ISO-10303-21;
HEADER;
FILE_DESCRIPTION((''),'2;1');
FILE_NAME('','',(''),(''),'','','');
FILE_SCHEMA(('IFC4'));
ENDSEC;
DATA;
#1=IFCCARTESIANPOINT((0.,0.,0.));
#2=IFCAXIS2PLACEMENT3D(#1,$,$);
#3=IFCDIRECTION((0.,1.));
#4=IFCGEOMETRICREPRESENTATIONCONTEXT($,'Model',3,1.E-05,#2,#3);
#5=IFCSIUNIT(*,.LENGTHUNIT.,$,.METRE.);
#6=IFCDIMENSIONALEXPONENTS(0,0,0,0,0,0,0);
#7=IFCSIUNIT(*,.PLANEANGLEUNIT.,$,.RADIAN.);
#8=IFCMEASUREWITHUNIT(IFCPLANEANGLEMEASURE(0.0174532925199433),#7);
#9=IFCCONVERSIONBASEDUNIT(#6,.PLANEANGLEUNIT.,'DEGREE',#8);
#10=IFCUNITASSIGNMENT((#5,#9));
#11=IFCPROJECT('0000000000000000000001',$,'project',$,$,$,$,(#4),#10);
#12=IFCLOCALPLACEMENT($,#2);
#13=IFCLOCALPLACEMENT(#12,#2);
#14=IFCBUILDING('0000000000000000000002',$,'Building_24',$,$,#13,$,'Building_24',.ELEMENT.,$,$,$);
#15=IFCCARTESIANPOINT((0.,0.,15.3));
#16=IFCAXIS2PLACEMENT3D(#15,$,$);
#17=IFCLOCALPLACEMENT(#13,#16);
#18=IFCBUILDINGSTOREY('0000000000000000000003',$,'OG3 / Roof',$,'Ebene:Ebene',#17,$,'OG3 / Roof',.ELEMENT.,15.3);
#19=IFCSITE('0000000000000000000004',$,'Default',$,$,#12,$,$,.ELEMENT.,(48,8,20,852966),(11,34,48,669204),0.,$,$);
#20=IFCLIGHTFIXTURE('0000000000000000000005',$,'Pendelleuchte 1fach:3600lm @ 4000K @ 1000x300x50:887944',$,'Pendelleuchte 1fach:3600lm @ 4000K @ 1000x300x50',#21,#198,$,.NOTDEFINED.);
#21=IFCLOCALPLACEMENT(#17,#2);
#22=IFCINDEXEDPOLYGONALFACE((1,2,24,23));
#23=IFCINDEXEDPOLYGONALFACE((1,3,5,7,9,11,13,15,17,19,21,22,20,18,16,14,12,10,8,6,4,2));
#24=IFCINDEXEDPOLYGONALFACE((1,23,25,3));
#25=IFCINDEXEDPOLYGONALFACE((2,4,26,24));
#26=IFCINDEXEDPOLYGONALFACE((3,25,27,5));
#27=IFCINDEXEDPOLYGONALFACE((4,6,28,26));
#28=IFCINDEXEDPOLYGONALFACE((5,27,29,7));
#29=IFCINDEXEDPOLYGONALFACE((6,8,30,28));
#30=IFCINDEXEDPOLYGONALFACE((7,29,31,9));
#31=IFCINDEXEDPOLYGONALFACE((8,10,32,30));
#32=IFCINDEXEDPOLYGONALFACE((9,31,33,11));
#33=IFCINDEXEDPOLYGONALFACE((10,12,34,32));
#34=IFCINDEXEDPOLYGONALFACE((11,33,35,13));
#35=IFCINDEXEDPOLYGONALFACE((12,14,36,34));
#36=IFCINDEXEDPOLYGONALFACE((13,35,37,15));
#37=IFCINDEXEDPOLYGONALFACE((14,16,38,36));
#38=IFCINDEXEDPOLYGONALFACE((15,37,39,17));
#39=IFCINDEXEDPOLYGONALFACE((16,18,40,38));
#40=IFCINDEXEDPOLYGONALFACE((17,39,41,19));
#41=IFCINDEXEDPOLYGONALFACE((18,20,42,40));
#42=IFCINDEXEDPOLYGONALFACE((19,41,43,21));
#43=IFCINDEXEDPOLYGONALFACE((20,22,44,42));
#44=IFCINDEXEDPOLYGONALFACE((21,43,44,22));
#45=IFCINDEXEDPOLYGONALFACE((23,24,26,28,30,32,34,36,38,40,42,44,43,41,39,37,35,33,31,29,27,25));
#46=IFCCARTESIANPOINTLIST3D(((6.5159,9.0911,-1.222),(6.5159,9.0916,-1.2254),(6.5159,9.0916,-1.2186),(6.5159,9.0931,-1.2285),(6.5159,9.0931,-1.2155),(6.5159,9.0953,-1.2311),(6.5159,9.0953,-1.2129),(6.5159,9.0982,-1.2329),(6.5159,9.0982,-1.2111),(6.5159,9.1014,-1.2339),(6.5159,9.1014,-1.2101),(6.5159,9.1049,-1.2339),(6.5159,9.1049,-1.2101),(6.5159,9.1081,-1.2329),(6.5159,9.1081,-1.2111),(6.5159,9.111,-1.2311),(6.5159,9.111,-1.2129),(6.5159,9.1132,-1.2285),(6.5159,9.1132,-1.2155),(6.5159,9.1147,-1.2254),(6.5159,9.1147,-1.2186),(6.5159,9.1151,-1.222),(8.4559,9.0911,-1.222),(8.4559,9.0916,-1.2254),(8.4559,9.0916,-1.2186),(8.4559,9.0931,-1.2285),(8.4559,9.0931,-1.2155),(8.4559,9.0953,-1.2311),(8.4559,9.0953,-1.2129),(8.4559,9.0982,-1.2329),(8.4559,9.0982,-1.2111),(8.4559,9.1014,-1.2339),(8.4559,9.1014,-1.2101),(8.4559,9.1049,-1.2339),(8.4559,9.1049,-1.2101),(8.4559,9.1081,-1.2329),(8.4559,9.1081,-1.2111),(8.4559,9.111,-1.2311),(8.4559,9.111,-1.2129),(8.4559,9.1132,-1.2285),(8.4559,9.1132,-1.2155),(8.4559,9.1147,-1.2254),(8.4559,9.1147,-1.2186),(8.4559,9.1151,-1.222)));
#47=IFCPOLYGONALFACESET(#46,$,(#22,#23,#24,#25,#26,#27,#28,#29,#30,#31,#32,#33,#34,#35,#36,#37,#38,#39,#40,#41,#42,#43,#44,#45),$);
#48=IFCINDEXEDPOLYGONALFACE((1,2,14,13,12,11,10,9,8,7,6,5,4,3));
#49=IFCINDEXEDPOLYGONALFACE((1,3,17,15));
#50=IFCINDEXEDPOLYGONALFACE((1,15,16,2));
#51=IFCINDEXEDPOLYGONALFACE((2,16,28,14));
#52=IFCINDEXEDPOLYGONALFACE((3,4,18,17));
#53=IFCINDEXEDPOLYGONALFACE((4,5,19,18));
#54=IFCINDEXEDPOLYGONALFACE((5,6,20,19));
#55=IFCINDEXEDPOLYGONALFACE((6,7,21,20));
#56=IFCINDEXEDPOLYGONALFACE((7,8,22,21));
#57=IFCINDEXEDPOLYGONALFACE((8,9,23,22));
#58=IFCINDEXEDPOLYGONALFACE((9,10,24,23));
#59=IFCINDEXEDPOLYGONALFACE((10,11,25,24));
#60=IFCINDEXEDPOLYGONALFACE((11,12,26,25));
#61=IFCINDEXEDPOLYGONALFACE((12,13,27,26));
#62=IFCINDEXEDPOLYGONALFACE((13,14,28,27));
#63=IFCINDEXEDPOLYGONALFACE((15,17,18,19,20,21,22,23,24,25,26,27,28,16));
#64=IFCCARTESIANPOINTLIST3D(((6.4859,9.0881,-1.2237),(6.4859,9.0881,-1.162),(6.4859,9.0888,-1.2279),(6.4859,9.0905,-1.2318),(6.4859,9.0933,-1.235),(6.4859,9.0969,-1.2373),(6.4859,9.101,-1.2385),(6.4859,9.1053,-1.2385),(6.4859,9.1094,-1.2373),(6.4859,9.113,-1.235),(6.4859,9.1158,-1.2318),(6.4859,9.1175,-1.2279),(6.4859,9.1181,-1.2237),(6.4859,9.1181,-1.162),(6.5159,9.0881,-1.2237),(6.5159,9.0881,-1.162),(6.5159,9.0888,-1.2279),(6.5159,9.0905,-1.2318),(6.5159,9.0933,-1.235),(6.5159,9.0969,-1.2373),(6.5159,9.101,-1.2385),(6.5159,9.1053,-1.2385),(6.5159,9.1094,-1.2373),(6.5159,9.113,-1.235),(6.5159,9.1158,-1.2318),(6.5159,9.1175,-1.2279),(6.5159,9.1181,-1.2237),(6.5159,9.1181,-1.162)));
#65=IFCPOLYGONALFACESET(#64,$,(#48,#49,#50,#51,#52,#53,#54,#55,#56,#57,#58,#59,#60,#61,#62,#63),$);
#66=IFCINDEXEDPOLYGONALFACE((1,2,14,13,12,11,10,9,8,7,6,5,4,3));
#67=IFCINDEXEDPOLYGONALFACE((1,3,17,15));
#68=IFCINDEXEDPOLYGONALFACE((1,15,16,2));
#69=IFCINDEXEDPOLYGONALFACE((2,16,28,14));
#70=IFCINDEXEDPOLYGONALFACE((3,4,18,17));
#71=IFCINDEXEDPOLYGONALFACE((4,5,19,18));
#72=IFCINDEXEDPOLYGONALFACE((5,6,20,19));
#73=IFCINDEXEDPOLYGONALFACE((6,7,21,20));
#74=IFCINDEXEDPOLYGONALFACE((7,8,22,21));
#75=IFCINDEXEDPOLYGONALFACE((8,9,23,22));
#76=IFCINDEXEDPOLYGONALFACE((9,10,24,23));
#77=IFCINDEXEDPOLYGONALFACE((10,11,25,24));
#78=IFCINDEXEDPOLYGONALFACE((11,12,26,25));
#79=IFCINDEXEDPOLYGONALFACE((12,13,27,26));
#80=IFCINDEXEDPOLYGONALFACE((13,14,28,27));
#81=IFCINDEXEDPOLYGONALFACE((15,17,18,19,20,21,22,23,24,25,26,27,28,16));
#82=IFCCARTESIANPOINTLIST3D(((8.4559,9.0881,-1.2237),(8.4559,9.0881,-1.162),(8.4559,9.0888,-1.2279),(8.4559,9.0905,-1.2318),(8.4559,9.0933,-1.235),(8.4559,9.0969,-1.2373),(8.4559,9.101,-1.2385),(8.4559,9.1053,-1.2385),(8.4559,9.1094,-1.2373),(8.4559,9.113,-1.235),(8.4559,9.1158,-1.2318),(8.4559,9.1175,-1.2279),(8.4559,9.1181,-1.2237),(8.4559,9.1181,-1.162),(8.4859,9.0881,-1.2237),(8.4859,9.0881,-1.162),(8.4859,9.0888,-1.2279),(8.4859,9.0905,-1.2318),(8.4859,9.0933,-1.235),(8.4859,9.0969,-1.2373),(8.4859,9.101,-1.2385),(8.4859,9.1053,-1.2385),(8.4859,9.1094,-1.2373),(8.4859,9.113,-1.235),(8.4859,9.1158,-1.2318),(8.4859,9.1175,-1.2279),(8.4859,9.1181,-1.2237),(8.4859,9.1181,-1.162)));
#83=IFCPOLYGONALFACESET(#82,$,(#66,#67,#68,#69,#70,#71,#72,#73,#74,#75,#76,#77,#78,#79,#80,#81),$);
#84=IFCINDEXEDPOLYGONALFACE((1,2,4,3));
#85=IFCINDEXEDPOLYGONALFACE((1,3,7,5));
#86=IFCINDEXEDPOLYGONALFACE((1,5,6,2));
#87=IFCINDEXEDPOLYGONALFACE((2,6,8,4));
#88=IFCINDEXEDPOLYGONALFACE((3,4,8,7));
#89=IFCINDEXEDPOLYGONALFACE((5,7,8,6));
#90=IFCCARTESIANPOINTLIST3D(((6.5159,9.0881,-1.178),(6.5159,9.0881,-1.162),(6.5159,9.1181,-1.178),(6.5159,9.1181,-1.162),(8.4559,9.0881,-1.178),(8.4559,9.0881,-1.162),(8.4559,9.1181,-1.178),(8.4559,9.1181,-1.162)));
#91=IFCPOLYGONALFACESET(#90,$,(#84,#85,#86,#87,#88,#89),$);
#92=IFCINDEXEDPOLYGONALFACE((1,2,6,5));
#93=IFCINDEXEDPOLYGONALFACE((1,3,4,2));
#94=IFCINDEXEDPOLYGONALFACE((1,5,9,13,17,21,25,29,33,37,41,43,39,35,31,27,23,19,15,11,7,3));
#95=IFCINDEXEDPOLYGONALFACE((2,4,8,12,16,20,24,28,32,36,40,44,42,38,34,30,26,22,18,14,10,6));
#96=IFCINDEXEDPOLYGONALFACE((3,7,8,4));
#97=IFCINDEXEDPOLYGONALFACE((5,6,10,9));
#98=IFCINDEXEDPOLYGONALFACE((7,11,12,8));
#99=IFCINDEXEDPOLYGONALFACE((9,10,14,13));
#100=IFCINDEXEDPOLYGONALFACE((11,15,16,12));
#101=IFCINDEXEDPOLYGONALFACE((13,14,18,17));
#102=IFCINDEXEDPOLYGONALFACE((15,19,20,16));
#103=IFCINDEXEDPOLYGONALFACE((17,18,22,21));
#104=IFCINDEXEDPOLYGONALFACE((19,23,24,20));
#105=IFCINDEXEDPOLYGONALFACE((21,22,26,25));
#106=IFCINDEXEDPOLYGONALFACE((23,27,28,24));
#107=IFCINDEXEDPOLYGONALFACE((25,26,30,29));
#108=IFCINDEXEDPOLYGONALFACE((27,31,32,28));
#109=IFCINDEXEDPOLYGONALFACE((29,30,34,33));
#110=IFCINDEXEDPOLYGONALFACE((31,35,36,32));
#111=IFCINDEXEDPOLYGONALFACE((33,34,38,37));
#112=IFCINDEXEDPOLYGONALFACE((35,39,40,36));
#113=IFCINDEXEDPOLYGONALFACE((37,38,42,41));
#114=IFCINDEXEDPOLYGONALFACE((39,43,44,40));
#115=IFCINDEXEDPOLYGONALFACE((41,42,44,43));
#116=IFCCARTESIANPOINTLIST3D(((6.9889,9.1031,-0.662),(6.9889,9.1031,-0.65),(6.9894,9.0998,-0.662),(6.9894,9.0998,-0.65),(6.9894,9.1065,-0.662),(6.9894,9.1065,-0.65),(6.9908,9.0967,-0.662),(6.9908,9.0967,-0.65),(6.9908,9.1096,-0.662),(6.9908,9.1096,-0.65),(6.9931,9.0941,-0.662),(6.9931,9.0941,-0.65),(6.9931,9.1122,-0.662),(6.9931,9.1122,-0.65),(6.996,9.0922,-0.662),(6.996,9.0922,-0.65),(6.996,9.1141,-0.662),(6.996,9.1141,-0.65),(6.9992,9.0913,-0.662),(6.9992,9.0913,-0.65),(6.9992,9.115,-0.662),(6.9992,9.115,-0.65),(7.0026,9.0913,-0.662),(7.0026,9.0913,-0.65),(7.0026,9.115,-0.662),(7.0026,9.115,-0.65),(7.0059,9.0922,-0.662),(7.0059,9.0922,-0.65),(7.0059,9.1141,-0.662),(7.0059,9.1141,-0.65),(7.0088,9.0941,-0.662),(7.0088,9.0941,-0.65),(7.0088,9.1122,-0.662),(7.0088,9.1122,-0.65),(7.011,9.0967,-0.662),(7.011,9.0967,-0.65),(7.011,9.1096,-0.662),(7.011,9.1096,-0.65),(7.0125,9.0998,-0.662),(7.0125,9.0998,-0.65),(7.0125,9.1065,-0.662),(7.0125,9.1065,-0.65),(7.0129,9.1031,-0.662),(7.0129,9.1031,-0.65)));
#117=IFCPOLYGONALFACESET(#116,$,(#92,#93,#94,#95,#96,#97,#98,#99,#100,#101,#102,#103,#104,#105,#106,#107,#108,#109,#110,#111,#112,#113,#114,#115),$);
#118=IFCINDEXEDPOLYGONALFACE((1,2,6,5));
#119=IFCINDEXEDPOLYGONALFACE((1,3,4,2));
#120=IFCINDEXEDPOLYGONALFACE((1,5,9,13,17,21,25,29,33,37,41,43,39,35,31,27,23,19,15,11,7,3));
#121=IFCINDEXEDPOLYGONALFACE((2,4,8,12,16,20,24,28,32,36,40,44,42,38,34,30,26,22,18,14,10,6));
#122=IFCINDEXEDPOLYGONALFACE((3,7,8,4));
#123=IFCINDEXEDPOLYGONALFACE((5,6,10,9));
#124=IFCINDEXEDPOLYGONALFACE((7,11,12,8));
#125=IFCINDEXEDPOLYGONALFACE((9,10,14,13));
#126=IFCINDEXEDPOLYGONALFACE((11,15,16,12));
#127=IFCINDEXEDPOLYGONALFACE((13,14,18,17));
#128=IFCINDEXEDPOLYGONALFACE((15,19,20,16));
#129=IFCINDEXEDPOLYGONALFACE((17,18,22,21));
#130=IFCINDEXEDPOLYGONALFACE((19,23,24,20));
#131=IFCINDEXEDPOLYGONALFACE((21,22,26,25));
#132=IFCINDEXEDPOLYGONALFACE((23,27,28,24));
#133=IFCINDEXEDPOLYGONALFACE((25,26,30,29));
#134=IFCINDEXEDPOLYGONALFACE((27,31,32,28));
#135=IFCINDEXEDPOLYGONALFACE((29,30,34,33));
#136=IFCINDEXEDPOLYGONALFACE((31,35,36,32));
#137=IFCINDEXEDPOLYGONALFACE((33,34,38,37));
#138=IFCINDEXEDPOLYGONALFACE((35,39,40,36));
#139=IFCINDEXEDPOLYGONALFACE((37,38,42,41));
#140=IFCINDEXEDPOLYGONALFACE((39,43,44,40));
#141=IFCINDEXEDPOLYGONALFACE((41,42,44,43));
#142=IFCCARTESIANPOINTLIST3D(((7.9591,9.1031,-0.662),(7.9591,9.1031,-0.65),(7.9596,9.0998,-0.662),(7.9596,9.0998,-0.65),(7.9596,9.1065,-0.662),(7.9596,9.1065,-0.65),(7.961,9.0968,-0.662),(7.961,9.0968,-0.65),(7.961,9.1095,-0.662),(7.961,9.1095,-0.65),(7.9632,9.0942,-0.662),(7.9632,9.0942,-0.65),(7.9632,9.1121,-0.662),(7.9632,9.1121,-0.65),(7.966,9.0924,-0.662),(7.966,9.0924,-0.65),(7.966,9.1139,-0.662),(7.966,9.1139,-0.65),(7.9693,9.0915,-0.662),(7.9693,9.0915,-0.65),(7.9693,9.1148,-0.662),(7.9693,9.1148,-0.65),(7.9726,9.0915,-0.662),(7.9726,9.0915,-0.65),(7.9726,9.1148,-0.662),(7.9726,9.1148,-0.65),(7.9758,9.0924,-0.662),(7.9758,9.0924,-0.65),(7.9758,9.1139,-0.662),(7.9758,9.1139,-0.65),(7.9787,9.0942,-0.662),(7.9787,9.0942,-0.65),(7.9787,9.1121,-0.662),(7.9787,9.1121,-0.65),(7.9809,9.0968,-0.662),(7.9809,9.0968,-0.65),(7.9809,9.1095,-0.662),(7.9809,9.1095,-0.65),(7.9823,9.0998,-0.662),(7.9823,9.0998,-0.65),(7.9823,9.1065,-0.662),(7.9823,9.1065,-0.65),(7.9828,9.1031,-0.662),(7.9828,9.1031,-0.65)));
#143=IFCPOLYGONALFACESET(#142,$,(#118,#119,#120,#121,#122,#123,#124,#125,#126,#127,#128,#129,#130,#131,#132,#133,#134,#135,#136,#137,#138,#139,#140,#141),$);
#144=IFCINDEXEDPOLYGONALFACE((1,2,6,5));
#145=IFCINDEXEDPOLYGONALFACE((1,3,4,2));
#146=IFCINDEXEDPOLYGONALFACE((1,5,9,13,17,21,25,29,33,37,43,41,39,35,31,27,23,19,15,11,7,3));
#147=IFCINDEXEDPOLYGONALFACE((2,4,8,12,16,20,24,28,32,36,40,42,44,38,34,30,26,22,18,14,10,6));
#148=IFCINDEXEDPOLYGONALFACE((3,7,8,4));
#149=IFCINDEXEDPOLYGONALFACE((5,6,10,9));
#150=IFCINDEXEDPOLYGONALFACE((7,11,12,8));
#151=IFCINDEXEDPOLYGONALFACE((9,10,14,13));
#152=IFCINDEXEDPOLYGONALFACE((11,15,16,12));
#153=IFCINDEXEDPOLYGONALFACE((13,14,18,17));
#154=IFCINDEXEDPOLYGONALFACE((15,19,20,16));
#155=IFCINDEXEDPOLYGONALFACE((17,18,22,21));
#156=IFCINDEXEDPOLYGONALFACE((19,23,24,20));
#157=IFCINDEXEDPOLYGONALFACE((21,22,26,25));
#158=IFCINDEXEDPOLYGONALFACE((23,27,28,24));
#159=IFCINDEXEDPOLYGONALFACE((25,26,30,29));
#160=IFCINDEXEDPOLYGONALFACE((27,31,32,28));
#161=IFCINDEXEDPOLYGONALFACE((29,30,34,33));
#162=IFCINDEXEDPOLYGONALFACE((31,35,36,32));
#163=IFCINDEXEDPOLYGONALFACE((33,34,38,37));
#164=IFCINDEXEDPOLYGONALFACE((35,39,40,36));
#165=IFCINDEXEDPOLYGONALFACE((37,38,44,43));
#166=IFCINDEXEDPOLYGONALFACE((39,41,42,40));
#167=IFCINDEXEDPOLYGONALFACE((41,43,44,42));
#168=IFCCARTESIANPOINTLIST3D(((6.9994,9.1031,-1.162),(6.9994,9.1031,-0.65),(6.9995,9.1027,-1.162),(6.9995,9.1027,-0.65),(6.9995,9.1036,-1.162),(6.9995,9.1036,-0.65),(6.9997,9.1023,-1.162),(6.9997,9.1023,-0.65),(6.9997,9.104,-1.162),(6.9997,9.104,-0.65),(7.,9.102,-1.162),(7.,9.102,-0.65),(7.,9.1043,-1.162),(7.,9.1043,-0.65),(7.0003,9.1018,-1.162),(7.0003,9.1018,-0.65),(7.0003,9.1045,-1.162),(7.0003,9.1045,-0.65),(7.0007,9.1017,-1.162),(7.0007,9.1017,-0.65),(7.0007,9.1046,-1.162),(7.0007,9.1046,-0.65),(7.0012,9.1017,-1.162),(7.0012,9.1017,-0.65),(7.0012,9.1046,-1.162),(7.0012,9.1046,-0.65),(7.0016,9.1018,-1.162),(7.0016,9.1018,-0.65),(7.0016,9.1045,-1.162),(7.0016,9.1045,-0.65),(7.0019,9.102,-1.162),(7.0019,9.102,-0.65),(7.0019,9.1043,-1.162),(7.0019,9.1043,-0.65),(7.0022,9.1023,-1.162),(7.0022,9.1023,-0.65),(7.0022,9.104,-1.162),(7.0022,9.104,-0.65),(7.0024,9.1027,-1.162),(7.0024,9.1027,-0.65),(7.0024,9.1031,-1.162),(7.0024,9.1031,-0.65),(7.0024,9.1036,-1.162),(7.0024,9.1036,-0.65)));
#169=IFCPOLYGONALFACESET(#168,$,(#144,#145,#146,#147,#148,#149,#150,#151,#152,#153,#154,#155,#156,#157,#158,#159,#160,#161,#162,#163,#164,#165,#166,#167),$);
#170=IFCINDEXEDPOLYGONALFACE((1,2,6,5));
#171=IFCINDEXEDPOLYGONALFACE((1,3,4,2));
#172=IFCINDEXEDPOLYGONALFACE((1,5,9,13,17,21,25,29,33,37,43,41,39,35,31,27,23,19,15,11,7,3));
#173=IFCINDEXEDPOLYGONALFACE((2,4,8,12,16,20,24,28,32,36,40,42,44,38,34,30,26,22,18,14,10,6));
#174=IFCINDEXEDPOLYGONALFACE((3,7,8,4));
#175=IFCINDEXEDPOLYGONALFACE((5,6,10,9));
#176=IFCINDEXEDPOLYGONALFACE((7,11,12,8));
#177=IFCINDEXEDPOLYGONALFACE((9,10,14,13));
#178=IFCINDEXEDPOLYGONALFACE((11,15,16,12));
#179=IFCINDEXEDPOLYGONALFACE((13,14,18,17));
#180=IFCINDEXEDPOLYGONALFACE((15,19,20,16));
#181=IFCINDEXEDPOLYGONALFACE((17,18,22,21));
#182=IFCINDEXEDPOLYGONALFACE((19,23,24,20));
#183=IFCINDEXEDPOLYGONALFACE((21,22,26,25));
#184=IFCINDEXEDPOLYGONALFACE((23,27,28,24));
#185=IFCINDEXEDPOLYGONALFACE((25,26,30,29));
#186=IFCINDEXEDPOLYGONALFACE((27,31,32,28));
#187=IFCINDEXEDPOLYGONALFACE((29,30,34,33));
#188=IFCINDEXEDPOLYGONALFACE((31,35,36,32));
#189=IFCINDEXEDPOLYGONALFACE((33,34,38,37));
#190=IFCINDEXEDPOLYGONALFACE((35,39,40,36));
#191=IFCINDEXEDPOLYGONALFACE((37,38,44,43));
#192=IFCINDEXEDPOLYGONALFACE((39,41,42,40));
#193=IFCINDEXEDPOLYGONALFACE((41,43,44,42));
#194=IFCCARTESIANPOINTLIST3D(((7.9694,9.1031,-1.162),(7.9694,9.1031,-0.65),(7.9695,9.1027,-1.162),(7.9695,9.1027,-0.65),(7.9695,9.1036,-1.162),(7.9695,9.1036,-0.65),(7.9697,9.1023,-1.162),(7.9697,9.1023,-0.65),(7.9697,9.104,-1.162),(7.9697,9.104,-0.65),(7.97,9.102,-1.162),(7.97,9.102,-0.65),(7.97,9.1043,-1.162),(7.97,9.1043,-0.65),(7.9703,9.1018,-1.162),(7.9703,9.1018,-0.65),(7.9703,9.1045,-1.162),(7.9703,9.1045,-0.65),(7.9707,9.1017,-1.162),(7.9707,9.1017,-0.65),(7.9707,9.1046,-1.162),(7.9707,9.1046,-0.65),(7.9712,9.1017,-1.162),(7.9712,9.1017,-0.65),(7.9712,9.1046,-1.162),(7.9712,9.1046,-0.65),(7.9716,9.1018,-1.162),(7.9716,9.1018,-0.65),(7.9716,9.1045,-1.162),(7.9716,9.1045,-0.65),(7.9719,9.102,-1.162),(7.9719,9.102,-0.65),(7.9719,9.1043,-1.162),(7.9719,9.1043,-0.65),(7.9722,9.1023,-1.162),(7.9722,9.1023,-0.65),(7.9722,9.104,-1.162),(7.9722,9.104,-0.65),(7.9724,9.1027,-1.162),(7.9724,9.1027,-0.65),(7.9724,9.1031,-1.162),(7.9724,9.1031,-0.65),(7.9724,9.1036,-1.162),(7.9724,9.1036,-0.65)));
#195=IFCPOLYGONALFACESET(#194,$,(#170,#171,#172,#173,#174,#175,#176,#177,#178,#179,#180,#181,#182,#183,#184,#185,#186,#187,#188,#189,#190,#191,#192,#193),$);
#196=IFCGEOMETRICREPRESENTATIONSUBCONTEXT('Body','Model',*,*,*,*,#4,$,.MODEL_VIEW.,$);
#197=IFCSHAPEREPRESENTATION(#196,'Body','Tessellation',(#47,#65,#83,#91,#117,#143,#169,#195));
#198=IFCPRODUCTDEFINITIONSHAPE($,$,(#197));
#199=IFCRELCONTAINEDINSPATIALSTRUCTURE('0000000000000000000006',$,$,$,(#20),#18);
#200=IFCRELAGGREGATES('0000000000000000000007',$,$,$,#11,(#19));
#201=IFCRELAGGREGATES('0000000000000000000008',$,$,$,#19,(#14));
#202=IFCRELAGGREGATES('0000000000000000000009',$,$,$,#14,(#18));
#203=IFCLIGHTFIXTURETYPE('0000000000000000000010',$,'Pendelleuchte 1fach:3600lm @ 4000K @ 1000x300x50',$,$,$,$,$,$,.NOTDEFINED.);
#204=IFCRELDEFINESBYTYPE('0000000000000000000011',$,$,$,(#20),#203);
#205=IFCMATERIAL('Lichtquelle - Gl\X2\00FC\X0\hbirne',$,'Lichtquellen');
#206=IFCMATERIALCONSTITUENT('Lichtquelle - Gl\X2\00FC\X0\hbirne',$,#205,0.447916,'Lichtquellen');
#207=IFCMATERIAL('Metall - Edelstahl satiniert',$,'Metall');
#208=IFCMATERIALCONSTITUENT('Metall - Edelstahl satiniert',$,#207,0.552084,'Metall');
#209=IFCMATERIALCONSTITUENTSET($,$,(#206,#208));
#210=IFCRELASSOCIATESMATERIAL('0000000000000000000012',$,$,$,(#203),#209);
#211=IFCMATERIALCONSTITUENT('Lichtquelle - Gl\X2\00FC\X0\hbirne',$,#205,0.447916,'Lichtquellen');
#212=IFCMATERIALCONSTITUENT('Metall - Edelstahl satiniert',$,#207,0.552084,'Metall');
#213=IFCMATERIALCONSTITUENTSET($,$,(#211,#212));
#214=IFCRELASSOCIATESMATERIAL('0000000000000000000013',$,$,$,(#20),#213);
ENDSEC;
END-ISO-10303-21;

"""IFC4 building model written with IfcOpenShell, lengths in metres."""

from ifc_helpers import new_model, entity, si_unit, converted_unit, direction, frame, origin, place, context, subcontext, project, spatial, line, arc, indexed_curve, outline, extrude, source, transform, mapped, material, constituent, constituent_set, type_object, type_shapes, element, save


model = new_model("IFC4")

# Units and contexts
model_context = context("Model", 3, precision=1e-05, world=origin(), true_north=direction((0.0, 1.0)))
body_context = subcontext(model_context, "Body", "Model", "MODEL_VIEW")
ifc_project = project(units=[si_unit("LENGTHUNIT", "METRE"), converted_unit("PLANEANGLEUNIT", "DEGREE", entity("IfcPlaneAngleMeasure", 0.0174532925199433), si_unit("PLANEANGLEUNIT", "RADIAN"), dimensions=[0, 0, 0, 0, 0, 0, 0])], contexts=[model_context])

# Site, building, storey
site_placement = place(None, origin())
site = spatial("IfcSite", under=ifc_project, at=site_placement, Name="Default", CompositionType="ELEMENT", RefLatitude=(48, 8, 20, 852966), RefLongitude=(11, 34, 48, 669204), RefElevation=0.0)
building_placement = place(site_placement, origin())
building = spatial("IfcBuilding", under=site, at=building_placement, Name="Building_24", LongName="Building_24", CompositionType="ELEMENT")
storey_placement = place(building_placement, frame((0.0, 0.0, 15.3)))
storey = spatial("IfcBuildingStorey", under=building, at=storey_placement, Name="OG3 / Roof", ObjectType="Ebene:Ebene", LongName="OG3 / Roof", CompositionType="ELEMENT", Elevation=15.3)

# Light fixture
ifc_material_1 = material(Name="Lichtquelle - Glühbirne", Category="Lichtquellen")
ifc_material_2 = material(Name="Metall - Edelstahl satiniert", Category="Metall")
ifc_constituent_1 = constituent(ifc_material_1, Name="Lichtquelle - Glühbirne", Category="Lichtquellen", fraction=0.447916)
ifc_constituent_2 = constituent(ifc_material_2, Name="Metall - Edelstahl satiniert", Category="Metall", fraction=0.552084)
ifc_constituent_set_1 = constituent_set(constituents=[ifc_constituent_1, ifc_constituent_2])
light_fixture_type_1 = type_object("IfcLightFixtureType", Name="Pendelleuchte 1fach:3600lm @ 4000K @ 1000x300x50", PredefinedType="NOTDEFINED", material=ifc_constituent_set_1)
shared_shape_1 = source(origin(), body_context, "Body", "SweptSolid", [
    extrude(outline(indexed_curve([(-0.012, 0.0), (0.0, -0.012), (0.012, 0.0), (0.0, 0.012)], segments=[arc(1, 2, 3), arc(3, 4, 1)], self_intersect=False)), frame((-0.97, 0.0, -0.572), z_axis=(1.0, 0.0, 0.0), x_axis=(0.0, -1.0, 0.0)), (0.0, 0.0, 1.0), 1.94),
    extrude(outline(indexed_curve([(0.015, 0.0308), (0.0, 0.0458), (-0.015, 0.0308), (-0.015, -0.0308), (0.015, -0.0308)], segments=[arc(1, 2, 3), line(3, 4, 5, 1)], self_intersect=False)), frame((0.97, 0.0, -0.5428), z_axis=(1.0, 0.0, 0.0), x_axis=(0.0, -1.0, 0.0)), (0.0, 0.0, 1.0), 0.03),
    extrude(outline(indexed_curve([(0.015, 0.0308), (0.0, 0.0458), (-0.015, 0.0308), (-0.015, -0.0308), (0.015, -0.0308)], segments=[arc(1, 2, 3), line(3, 4, 5, 1)], self_intersect=False)), frame((-1.0, 0.0, -0.5428), z_axis=(1.0, 0.0, 0.0), x_axis=(0.0, -1.0, 0.0)), (0.0, 0.0, 1.0), 0.03),
    extrude(outline(indexed_curve([(-0.015, -0.97), (0.015, -0.97), (0.015, 0.97), (-0.015, 0.97), (-0.015, -0.97)], self_intersect=False)), frame((0.0, 0.0, -0.528), z_axis=(0.0, 0.0, 1.0), x_axis=(0.0, 1.0, 0.0)), (0.0, 0.0, 1.0), 0.016),
    extrude(outline(indexed_curve([(-0.012, 0.0), (0.0, -0.012), (0.012, 0.0), (0.0, 0.012)], segments=[arc(1, 2, 3), arc(3, 4, 1)], self_intersect=False)), frame((0.485, 0.0, -0.012)), (0.0, 0.0, 1.0), 0.012),
    extrude(outline(indexed_curve([(-0.0118, 0.0), (0.0, -0.0118), (0.0118, 0.0), (0.0, 0.0118)], segments=[arc(1, 2, 3), arc(3, 4, 1)], self_intersect=False)), frame((-0.485, 0.0, -0.012)), (0.0, 0.0, 1.0), 0.012),
    extrude(outline(indexed_curve([(-0.0015, 0.0), (0.0, -0.0015), (0.0015, 0.0), (0.0, 0.0015)], segments=[arc(1, 2, 3), arc(3, 4, 1)], self_intersect=False)), frame((0.485, 0.0, -0.512)), (0.0, 0.0, 1.0), 0.512),
    extrude(outline(indexed_curve([(-0.0015, 0.0), (0.0, -0.0015), (0.0015, 0.0), (0.0, 0.0015)], segments=[arc(1, 2, 3), arc(3, 4, 1)], self_intersect=False)), frame((-0.485, 0.0, -0.512)), (0.0, 0.0, 1.0), 0.512),
])
type_shapes(light_fixture_type_1, [shared_shape_1])
ifc_constituent_3 = constituent(ifc_material_1, Name="Lichtquelle - Glühbirne", Category="Lichtquellen", fraction=0.447916)
ifc_constituent_4 = constituent(ifc_material_2, Name="Metall - Edelstahl satiniert", Category="Metall", fraction=0.552084)
ifc_constituent_set_2 = constituent_set(constituents=[ifc_constituent_3, ifc_constituent_4])
light_fixture_1_placement = place(storey_placement, frame((7.4859, 9.1031, -0.65), z_axis=(0.0, 0.0, 1.0), x_axis=(-1.0, 0.0, 0.0)))
element("IfcLightFixture", 1, at=light_fixture_1_placement, inside=storey, type_object=light_fixture_type_1, material=ifc_constituent_set_2, Name="Pendelleuchte 1fach:3600lm @ 4000K @ 1000x300x50:887944", ObjectType="Pendelleuchte 1fach:3600lm @ 4000K @ 1000x300x50", PredefinedType="NOTDEFINED", context=body_context, shape_type="MappedRepresentation", body=[
    mapped(shared_shape_1, transform((0.0, 0.0, 0.0), scale=1.0)),
])

save(model, "model.ifc")
